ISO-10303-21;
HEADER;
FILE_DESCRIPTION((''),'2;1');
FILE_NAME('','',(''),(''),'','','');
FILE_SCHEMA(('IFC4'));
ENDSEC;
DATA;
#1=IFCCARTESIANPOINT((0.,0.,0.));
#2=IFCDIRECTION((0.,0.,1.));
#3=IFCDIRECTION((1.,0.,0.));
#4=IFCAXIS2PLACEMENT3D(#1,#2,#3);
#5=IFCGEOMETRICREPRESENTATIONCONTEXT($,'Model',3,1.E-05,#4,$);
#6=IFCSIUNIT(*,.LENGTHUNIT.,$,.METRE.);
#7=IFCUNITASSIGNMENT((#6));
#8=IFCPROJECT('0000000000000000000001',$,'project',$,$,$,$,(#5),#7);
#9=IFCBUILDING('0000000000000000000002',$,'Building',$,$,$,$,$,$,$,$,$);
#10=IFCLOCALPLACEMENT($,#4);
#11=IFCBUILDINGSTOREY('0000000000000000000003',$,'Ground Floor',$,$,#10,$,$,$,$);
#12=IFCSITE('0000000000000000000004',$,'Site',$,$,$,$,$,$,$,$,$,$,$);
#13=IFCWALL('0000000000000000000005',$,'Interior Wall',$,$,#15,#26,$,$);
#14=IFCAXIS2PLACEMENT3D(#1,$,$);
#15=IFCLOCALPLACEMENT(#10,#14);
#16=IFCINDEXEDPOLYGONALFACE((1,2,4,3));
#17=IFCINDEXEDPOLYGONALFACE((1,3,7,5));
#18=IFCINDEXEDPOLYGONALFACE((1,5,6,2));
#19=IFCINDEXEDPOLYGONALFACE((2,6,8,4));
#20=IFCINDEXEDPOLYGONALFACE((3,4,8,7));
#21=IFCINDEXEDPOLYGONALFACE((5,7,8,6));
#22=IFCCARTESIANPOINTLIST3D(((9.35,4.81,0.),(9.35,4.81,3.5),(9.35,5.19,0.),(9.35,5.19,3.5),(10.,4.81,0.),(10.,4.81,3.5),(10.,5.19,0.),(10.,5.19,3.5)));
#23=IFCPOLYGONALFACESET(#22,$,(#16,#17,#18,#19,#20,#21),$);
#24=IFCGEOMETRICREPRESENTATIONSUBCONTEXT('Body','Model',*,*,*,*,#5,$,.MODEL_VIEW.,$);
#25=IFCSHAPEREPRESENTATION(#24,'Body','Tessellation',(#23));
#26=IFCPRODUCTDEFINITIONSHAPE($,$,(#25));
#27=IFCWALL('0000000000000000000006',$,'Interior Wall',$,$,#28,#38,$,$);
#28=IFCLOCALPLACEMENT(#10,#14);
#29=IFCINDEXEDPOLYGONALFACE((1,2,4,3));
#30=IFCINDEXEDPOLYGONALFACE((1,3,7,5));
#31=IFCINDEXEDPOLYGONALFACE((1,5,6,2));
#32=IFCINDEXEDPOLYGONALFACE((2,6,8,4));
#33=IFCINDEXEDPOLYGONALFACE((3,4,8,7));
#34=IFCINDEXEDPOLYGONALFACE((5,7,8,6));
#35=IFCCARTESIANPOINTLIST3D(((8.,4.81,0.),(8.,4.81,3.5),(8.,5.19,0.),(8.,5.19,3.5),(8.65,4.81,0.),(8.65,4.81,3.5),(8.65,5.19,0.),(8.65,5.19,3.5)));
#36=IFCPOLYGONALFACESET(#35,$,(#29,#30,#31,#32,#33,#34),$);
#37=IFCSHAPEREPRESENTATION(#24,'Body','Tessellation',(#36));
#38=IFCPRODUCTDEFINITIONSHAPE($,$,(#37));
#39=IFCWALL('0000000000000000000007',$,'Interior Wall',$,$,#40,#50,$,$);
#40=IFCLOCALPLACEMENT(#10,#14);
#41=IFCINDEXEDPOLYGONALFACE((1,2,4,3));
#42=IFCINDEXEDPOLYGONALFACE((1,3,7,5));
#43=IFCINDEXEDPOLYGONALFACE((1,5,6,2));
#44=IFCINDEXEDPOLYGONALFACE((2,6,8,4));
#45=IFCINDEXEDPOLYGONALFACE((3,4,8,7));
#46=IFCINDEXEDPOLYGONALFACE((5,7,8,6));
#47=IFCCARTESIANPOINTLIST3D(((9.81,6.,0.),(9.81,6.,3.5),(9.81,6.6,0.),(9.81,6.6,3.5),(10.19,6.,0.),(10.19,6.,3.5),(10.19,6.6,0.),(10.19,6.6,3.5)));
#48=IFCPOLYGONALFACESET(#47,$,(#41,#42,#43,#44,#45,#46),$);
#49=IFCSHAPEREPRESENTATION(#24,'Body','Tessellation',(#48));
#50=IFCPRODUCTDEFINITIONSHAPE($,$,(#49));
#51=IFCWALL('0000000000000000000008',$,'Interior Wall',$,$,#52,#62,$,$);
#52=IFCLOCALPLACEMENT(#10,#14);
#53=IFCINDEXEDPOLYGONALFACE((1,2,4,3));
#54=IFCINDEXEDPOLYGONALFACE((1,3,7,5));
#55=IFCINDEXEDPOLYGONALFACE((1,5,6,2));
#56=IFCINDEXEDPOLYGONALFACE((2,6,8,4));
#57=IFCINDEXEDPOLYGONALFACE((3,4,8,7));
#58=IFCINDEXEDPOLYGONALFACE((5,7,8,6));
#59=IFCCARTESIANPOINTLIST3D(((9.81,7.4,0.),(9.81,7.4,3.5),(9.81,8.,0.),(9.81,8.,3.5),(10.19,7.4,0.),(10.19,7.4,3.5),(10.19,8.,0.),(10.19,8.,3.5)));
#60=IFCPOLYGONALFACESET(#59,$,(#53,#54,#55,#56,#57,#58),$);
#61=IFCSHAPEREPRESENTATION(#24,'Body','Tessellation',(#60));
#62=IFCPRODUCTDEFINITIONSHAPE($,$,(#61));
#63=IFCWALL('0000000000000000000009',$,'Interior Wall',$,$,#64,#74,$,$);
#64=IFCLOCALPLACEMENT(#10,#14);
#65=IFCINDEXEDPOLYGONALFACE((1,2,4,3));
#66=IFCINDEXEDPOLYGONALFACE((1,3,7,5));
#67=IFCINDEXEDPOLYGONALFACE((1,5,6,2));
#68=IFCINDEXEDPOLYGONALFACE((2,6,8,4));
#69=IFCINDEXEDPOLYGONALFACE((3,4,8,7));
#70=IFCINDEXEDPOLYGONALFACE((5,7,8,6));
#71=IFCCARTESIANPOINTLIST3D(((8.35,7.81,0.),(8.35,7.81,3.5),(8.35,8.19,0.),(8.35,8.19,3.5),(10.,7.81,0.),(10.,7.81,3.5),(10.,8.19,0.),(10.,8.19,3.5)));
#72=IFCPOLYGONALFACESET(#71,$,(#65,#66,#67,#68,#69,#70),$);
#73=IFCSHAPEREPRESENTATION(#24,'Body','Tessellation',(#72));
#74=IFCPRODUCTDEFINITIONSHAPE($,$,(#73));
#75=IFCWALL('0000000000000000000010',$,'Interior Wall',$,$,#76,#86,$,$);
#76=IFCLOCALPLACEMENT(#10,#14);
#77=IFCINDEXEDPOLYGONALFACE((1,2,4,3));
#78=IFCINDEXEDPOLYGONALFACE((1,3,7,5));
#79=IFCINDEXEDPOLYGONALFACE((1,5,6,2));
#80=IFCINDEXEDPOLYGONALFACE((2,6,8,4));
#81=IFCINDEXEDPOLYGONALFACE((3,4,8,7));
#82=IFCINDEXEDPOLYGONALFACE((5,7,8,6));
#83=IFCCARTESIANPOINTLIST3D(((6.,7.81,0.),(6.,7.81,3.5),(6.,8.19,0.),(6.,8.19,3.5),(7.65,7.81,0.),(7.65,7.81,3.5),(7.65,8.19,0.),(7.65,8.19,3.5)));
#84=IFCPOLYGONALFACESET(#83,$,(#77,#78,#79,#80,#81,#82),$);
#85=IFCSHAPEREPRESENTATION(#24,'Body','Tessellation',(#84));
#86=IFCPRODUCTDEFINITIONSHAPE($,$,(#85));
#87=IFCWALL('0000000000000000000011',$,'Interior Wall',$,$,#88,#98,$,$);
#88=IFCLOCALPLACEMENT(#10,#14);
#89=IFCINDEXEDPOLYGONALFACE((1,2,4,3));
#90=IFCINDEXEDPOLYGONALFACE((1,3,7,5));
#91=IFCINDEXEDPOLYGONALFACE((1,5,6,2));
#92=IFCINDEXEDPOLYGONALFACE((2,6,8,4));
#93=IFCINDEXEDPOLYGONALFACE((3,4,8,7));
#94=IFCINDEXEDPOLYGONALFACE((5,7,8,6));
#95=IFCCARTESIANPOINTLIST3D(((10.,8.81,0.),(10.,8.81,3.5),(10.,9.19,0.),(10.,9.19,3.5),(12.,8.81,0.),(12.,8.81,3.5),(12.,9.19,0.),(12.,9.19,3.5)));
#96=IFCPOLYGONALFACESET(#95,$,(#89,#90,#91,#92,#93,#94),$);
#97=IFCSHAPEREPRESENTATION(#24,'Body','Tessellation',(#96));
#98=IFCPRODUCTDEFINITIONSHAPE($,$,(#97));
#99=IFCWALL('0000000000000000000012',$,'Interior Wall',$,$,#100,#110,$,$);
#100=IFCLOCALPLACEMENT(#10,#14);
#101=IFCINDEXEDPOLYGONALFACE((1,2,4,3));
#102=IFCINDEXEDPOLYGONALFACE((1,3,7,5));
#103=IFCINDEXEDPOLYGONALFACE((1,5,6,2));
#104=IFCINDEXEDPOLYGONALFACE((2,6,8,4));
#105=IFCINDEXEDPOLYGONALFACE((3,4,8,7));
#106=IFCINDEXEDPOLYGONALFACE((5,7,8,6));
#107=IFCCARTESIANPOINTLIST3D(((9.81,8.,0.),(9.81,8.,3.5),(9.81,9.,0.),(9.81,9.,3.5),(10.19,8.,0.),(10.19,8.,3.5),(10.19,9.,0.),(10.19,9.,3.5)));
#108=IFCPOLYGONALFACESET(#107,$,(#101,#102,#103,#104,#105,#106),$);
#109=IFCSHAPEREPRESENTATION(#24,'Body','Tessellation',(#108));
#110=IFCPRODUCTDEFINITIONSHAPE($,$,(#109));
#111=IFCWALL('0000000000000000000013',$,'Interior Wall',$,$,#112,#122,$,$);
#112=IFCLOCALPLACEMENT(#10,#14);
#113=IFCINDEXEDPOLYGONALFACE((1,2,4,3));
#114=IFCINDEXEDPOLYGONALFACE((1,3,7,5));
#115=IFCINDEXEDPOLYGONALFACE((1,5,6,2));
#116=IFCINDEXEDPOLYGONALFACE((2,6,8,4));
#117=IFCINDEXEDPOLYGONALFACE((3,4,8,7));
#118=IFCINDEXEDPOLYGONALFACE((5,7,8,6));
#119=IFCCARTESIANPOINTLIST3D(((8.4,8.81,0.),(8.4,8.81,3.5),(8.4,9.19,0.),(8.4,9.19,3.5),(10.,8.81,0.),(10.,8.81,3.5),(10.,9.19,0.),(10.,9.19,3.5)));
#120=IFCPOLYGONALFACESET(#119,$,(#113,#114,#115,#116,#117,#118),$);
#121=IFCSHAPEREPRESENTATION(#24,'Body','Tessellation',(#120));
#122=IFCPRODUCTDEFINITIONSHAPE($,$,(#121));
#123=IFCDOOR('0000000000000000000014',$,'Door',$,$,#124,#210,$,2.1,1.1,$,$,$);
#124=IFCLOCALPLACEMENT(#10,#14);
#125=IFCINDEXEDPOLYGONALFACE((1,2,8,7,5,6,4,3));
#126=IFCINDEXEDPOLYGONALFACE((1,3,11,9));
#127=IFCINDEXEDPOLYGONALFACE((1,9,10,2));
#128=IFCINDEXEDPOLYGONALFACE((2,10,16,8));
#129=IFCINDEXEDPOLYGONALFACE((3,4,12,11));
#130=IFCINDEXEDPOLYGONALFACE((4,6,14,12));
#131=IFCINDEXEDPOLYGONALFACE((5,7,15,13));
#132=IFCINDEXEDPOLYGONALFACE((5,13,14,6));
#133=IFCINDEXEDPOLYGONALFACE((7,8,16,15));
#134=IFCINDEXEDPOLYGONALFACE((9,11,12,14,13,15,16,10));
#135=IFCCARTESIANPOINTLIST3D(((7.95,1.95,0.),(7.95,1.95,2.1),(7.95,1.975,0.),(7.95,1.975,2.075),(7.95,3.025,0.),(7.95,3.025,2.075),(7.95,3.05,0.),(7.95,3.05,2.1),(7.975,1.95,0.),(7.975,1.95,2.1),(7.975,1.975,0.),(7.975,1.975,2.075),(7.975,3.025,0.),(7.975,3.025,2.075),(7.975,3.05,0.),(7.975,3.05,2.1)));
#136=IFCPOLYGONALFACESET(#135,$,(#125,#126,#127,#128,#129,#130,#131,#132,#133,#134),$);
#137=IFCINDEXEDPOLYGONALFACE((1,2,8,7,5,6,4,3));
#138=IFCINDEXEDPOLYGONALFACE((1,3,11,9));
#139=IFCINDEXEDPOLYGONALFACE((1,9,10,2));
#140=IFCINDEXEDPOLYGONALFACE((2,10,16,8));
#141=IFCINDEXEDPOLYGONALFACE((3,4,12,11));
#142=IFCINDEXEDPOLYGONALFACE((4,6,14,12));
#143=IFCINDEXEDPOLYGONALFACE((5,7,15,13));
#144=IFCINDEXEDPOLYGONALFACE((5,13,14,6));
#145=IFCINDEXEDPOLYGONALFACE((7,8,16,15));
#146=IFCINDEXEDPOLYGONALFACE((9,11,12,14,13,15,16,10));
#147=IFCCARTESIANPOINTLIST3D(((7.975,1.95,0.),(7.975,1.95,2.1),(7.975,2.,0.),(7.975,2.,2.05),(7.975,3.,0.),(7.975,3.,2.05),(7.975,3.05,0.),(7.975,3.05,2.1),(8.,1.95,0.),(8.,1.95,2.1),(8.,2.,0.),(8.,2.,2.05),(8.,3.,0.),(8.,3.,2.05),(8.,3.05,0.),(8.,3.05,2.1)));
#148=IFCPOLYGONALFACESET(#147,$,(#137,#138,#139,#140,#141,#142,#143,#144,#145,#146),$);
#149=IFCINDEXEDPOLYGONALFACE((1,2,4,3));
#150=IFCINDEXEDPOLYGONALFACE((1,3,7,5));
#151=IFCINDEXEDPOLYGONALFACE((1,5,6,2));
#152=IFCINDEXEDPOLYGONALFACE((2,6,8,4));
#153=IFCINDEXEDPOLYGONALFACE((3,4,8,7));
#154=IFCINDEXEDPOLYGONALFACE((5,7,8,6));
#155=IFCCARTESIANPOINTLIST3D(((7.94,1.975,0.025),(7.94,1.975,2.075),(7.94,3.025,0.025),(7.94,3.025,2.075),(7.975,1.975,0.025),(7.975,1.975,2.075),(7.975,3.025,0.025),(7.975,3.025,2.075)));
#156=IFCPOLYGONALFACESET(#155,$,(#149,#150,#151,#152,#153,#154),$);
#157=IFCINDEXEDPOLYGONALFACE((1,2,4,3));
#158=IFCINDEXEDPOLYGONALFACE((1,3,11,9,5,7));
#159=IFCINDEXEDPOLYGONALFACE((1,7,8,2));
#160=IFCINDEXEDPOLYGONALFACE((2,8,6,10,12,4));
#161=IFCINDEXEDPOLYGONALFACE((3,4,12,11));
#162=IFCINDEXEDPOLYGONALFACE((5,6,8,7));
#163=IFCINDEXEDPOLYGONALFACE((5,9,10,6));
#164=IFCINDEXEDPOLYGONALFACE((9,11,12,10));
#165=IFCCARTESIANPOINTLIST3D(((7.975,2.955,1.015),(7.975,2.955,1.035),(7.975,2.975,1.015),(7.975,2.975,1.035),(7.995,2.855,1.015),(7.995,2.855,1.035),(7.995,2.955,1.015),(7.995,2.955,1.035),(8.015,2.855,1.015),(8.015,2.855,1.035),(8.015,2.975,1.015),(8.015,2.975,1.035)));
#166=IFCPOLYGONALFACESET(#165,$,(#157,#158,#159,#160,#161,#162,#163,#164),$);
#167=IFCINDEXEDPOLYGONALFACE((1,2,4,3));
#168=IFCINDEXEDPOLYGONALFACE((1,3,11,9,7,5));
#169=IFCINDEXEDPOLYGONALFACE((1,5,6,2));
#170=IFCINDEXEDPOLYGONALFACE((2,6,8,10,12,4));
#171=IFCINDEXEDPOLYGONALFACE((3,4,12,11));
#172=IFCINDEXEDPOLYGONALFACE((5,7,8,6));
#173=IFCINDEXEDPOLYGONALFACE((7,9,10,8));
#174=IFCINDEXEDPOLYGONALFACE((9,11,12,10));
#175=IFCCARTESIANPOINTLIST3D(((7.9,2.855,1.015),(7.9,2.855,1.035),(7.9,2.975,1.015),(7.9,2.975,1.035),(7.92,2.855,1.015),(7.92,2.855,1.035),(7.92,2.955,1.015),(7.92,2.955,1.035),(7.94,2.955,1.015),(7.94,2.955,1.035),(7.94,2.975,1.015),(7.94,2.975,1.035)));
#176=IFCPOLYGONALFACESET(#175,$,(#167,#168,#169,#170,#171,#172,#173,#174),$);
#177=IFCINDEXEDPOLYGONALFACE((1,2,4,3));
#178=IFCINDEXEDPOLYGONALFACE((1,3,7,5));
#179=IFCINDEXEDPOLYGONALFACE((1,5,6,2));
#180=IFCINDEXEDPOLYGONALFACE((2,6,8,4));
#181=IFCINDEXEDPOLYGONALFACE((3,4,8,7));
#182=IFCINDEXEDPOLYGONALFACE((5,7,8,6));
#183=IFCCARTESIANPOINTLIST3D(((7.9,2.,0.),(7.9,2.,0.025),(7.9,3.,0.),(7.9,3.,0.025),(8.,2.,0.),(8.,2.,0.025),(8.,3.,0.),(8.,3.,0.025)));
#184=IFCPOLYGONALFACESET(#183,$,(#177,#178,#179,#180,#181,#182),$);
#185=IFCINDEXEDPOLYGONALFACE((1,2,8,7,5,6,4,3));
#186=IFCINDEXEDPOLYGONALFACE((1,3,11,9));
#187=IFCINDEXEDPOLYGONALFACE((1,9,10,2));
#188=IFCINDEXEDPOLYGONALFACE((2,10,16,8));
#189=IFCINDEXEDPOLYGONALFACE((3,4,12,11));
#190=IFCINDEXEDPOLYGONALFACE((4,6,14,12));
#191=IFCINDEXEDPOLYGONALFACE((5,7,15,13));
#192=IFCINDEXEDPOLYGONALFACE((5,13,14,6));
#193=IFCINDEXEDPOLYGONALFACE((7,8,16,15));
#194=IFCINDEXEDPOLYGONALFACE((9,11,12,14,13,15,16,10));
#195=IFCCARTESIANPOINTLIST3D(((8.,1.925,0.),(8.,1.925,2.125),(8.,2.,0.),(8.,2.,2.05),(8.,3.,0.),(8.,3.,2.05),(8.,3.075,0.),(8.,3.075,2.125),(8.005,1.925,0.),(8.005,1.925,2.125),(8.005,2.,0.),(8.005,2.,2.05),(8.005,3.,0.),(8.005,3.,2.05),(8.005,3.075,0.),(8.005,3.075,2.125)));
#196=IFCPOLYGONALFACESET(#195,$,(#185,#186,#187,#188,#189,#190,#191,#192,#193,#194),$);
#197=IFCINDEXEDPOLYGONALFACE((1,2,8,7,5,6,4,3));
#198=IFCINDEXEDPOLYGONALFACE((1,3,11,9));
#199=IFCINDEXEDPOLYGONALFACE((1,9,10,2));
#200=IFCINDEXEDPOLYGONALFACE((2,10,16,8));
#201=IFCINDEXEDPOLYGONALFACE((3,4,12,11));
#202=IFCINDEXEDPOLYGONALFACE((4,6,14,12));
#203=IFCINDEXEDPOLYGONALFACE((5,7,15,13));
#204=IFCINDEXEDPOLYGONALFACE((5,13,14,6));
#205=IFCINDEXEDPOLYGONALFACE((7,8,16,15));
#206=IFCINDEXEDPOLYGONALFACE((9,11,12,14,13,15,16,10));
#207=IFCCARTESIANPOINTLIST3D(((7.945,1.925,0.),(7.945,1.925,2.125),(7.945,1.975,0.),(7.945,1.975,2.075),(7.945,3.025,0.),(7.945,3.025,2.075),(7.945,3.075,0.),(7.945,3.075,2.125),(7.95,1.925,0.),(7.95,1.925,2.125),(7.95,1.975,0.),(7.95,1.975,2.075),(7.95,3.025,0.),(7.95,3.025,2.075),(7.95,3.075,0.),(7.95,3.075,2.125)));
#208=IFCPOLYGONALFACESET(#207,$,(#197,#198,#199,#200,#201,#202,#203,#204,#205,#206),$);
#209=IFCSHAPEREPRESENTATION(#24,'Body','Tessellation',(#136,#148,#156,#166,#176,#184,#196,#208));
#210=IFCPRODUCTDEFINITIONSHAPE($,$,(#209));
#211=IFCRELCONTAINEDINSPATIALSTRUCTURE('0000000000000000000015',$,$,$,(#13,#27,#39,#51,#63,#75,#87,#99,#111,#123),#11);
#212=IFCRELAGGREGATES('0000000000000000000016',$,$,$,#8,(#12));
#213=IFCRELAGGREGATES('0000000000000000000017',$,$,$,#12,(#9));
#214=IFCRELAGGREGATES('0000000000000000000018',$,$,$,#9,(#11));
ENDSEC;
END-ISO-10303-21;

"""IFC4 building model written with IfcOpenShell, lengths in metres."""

from ifc_helpers import new_model, si_unit, frame, origin_with_axes, place, context, subcontext, project, spatial, line, indexed_curve, outline, extrude, element, save


model = new_model("IFC4")

# Units and contexts
model_context = context("Model", 3, precision=1e-05, world=origin_with_axes())
body_context = subcontext(model_context, "Body", "Model", "MODEL_VIEW")
ifc_project = project(units=[si_unit("LENGTHUNIT", "METRE")], contexts=[model_context])

# Site, building, storey
site = spatial("IfcSite", under=ifc_project, Name="Site")
building = spatial("IfcBuilding", under=site, Name="Building")
storey_placement = place(None, origin_with_axes())
storey = spatial("IfcBuildingStorey", under=building, at=storey_placement, Name="Ground Floor")

# Walls
for number, where, z_axis, x_axis, name in (
    (1, (10.0, 5.0, 0.0), (0.0, 0.0, 1.0), (-1.0, 0.0, 0.0), "Interior Wall"),
    (2, (8.65, 5.0, 0.0), (0.0, 0.0, 1.0), (-1.0, 0.0, 0.0), "Interior Wall"),
):
    element("IfcWall", number, at=place(storey_placement, frame(where, z_axis=z_axis, x_axis=x_axis)), inside=storey, Name=name, context=body_context, shape_type="SweptSolid", body=[
        extrude(outline(indexed_curve([(0.0, 0.0), (0.0, 0.38), (0.65, 0.38), (0.65, 0.0), (0.0, 0.0)], self_intersect=False)), frame((0.0, -0.19, 0.0), z_axis=(0.0, 0.0, 1.0), x_axis=(1.0, 0.0, 0.0)), (0.0, 0.0, 1.0), 3.5),
    ])
for number, where, z_axis, x_axis, name in (
    (3, (10.0, 6.0, 0.0), (0.0, 0.0, 1.0), (0.0, 1.0, 0.0), "Interior Wall"),
    (4, (10.0, 7.4, 0.0), (0.0, 0.0, 1.0), (0.0, 1.0, 0.0), "Interior Wall"),
):
    element("IfcWall", number, at=place(storey_placement, frame(where, z_axis=z_axis, x_axis=x_axis)), inside=storey, Name=name, context=body_context, shape_type="SweptSolid", body=[
        extrude(outline(indexed_curve([(0.0, 0.0), (0.0, 0.38), (0.6, 0.38), (0.6, 0.0), (0.0, 0.0)], self_intersect=False)), frame((0.0, -0.19, 0.0), z_axis=(0.0, 0.0, 1.0), x_axis=(1.0, 0.0, 0.0)), (0.0, 0.0, 1.0), 3.5),
    ])
for number, where, z_axis, x_axis, name in (
    (5, (10.0, 8.0, 0.0), (0.0, 0.0, 1.0), (-1.0, 0.0, 0.0), "Interior Wall"),
    (6, (7.65, 8.0, 0.0), (0.0, 0.0, 1.0), (-1.0, 0.0, 0.0), "Interior Wall"),
):
    element("IfcWall", number, at=place(storey_placement, frame(where, z_axis=z_axis, x_axis=x_axis)), inside=storey, Name=name, context=body_context, shape_type="SweptSolid", body=[
        extrude(outline(indexed_curve([(0.0, 0.0), (0.0, 0.38), (1.65, 0.38), (1.65, 0.0), (0.0, 0.0)], self_intersect=False)), frame((0.0, -0.19, 0.0), z_axis=(0.0, 0.0, 1.0), x_axis=(1.0, 0.0, 0.0)), (0.0, 0.0, 1.0), 3.5),
    ])
wall_1_placement = place(storey_placement, frame((12.0, 9.0, 0.0), z_axis=(0.0, 0.0, 1.0), x_axis=(-1.0, 0.0, 0.0)))
element("IfcWall", 7, at=wall_1_placement, inside=storey, Name="Interior Wall", context=body_context, shape_type="SweptSolid", body=[
    extrude(outline(indexed_curve([(0.0, 0.0), (0.0, 0.38), (2.0, 0.38), (2.0, 0.0), (0.0, 0.0)], self_intersect=False)), frame((0.0, -0.19, 0.0), z_axis=(0.0, 0.0, 1.0), x_axis=(1.0, 0.0, 0.0)), (0.0, 0.0, 1.0), 3.5),
])
wall_2_placement = place(storey_placement, frame((10.0, 9.0, 0.0), z_axis=(0.0, 0.0, 1.0), x_axis=(0.0, -1.0, 0.0)))
element("IfcWall", 8, at=wall_2_placement, inside=storey, Name="Interior Wall", context=body_context, shape_type="SweptSolid", body=[
    extrude(outline(indexed_curve([(0.0, 0.0), (0.0, 0.38), (1.0, 0.38), (1.0, 0.0), (0.0, 0.0)], self_intersect=False)), frame((0.0, -0.19, 0.0), z_axis=(0.0, 0.0, 1.0), x_axis=(1.0, 0.0, 0.0)), (0.0, 0.0, 1.0), 3.5),
])
wall_3_placement = place(storey_placement, frame((8.4, 9.0, 0.0), z_axis=(0.0, 0.0, 1.0), x_axis=(1.0, 0.0, 0.0)))
element("IfcWall", 9, at=wall_3_placement, inside=storey, Name="Interior Wall", context=body_context, shape_type="SweptSolid", body=[
    extrude(outline(indexed_curve([(0.0, 0.0), (0.0, 0.38), (1.6, 0.38), (1.6, 0.0), (0.0, 0.0)], self_intersect=False)), frame((0.0, -0.19, 0.0), z_axis=(0.0, 0.0, 1.0), x_axis=(1.0, 0.0, 0.0)), (0.0, 0.0, 1.0), 3.5),
])

# Door
door_1_placement = place(storey_placement, frame((8.0, 1.95, 0.0), z_axis=(0.0, 0.0, 1.0), x_axis=(0.0, 1.0, 0.0)))
element("IfcDoor", 10, at=door_1_placement, inside=storey, Name="Door", OverallHeight=2.1, OverallWidth=1.1, context=body_context, shape_type="SweptSolid", body=[
    extrude(outline(indexed_curve([(0.0, 0.0), (0.0, 2.1), (1.1, 2.1), (1.1, 0.0), (1.075, 0.0), (1.075, 2.075), (0.025, 2.075), (0.025, 0.0)], segments=[line(1, 2, 3, 4, 5, 6, 7, 8, 1)])), frame((0.0, 0.025, 0.0), z_axis=(0.0, -1.0, 0.0), x_axis=(1.0, 0.0, 0.0)), (0.0, 0.0, -1.0), 0.025),
    extrude(outline(indexed_curve([(0.0, 0.0), (0.0, 2.1), (1.1, 2.1), (1.1, 0.0), (1.05, 0.0), (1.05, 2.05), (0.05, 2.05), (0.05, 0.0)], segments=[line(1, 2, 3, 4, 5, 6, 7, 8, 1)])), frame((0.0, 0.0, 0.0), z_axis=(0.0, -1.0, 0.0), x_axis=(1.0, 0.0, 0.0)), (0.0, 0.0, -1.0), 0.025),
    extrude(outline(indexed_curve([(0.0, 0.0), (1.05, 0.0), (1.05, 0.035), (0.0, 0.035)], segments=[line(1, 2, 3, 4, 1)])), frame((0.025, 0.025, 0.025), z_axis=(0.0, 0.0, 1.0), x_axis=(1.0, 0.0, 0.0)), (0.0, 0.0, 1.0), 2.05),
    extrude(outline(indexed_curve([(0.0, 0.0), (0.0, -0.04), (-0.12, -0.04), (-0.12, -0.02), (-0.02, -0.02), (-0.02, 0.0)], segments=[line(1, 2, 3, 4, 5, 6, 1)])), frame((1.025, 0.025, 1.015), z_axis=(0.0, 0.0, 1.0), x_axis=(1.0, 0.0, 0.0)), (0.0, 0.0, 1.0), 0.02),
    extrude(outline(indexed_curve([(0.0, 0.0), (0.0, 0.04), (-0.12, 0.04), (-0.12, 0.02), (-0.02, 0.02), (-0.02, 0.0)], segments=[line(1, 2, 3, 4, 5, 6, 1)])), frame((1.025, 0.06, 1.015), z_axis=(0.0, 0.0, 1.0), x_axis=(1.0, 0.0, 0.0)), (0.0, 0.0, 1.0), 0.02),
    extrude(outline(indexed_curve([(0.0, 0.0), (1.0, 0.0), (1.0, 0.1), (0.0, 0.1)], segments=[line(1, 2, 3, 4, 1)])), frame((0.05, 0.0, 0.0), z_axis=(0.0, 0.0, 1.0), x_axis=(1.0, 0.0, 0.0)), (0.0, 0.0, 1.0), 0.025),
    extrude(outline(indexed_curve([(0.0, 0.0), (0.0, 2.125), (1.15, 2.125), (1.15, 0.0), (1.075, 0.0), (1.075, 2.05), (0.075, 2.05), (0.075, 0.0)], segments=[line(1, 2, 3, 4, 5, 6, 7, 8, 1)])), frame((-0.025, -0.005, 0.0), z_axis=(0.0, -1.0, 0.0), x_axis=(1.0, 0.0, 0.0)), (0.0, 0.0, -1.0), 0.005),
    extrude(outline(indexed_curve([(0.0, 0.0), (0.0, 2.125), (1.15, 2.125), (1.15, 0.0), (1.1, 0.0), (1.1, 2.075), (0.05, 2.075), (0.05, 0.0)], segments=[line(1, 2, 3, 4, 5, 6, 7, 8, 1)])), frame((-0.025, 0.05, 0.0), z_axis=(0.0, -1.0, 0.0), x_axis=(1.0, 0.0, 0.0)), (0.0, 0.0, -1.0), 0.005),
])

save(model, "model.ifc")
